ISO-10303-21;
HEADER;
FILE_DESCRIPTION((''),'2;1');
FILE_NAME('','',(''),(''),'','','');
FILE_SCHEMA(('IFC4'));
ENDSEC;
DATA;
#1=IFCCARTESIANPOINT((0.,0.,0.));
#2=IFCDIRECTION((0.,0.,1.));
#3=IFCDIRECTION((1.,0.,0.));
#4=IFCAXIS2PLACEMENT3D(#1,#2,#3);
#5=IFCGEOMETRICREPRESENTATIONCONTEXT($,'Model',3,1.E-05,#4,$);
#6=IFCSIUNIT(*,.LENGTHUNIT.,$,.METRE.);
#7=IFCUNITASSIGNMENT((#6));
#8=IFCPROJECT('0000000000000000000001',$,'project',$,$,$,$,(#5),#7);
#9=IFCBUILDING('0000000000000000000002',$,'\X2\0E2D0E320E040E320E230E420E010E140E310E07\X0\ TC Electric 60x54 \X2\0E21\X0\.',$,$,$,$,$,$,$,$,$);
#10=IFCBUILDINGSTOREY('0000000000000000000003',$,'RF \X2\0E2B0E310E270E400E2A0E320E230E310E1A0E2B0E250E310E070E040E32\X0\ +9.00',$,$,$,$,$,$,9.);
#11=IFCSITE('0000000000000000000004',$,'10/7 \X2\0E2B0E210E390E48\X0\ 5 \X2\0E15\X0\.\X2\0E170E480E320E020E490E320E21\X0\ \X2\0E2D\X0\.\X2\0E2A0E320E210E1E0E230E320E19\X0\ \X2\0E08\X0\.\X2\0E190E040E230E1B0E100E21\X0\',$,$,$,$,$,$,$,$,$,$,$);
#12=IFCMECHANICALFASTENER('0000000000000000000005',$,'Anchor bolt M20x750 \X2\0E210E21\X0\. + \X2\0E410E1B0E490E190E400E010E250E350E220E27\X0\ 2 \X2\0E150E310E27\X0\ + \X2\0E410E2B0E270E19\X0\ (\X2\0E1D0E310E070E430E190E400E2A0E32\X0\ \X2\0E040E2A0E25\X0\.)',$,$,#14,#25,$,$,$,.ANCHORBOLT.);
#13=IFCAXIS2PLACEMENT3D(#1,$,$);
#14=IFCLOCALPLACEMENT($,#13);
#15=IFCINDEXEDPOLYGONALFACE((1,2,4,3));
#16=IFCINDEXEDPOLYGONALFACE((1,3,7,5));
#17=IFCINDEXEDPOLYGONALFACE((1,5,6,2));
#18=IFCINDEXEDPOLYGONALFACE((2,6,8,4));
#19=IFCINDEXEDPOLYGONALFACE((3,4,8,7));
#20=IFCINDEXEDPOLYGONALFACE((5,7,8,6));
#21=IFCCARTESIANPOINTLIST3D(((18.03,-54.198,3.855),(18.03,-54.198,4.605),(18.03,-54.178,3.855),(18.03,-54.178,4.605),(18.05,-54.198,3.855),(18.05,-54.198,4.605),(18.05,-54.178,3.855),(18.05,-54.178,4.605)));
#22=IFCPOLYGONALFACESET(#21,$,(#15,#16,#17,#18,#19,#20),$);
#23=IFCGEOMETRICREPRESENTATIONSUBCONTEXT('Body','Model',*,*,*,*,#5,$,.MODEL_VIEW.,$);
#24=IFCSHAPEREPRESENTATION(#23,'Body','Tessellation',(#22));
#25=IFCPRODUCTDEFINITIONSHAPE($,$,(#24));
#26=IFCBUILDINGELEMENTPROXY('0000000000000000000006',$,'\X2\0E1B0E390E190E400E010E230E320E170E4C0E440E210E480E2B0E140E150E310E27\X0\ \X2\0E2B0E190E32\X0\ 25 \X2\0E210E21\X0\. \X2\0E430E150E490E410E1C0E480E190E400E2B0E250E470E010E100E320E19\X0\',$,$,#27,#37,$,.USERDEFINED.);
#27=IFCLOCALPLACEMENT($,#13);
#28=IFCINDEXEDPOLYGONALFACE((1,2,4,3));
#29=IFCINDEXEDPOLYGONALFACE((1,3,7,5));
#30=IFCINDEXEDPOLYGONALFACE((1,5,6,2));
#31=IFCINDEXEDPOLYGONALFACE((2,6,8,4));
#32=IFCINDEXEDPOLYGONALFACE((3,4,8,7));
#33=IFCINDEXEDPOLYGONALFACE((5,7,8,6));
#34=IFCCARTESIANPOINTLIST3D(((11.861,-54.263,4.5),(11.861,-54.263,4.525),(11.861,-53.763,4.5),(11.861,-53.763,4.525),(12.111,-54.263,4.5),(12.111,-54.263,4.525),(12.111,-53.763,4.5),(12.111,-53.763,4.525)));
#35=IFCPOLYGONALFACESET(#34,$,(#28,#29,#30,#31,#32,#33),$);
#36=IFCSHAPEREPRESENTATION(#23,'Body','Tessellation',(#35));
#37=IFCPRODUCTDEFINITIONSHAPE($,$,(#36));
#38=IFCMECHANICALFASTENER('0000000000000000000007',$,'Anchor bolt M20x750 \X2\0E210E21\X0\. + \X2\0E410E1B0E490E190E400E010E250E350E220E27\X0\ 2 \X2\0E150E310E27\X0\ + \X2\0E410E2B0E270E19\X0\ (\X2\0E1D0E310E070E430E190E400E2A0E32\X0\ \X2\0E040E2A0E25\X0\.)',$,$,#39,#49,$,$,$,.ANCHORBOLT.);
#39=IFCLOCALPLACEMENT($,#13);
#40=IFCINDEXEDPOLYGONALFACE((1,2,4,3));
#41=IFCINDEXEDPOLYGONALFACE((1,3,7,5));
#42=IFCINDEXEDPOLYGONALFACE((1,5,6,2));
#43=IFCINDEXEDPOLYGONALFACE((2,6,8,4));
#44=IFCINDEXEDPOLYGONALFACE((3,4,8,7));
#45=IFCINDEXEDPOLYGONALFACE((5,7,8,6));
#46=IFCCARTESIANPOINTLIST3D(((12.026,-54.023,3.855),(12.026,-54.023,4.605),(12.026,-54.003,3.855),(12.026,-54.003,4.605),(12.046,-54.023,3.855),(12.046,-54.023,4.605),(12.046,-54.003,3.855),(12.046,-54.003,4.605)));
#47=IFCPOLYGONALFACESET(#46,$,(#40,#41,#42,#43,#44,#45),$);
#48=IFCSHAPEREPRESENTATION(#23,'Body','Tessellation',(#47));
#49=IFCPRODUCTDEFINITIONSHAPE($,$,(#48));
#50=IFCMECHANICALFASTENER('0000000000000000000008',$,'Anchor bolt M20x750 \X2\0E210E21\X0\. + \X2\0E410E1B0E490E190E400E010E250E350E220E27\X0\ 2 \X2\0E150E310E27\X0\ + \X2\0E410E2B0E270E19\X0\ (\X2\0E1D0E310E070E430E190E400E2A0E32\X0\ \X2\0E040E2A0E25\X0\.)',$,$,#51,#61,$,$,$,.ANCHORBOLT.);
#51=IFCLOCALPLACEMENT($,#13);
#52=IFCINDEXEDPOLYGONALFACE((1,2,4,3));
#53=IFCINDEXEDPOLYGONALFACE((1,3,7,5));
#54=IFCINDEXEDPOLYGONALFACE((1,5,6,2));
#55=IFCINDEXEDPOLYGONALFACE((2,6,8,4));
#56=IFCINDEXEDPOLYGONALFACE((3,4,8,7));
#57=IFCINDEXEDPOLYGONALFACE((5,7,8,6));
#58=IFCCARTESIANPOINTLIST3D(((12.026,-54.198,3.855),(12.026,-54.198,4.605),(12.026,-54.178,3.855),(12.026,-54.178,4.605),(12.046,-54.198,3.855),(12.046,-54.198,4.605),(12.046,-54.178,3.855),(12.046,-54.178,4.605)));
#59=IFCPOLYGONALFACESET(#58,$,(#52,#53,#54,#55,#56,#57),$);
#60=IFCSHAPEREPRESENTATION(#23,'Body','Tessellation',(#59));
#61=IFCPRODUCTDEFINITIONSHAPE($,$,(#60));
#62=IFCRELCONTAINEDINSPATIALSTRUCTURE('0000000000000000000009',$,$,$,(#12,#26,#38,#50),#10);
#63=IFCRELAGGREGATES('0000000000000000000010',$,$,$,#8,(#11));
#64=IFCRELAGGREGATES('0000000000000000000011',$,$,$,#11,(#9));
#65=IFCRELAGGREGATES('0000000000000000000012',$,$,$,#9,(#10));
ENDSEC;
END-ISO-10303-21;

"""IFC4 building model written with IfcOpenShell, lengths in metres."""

from ifc_helpers import new_model, si_unit, frame, origin, origin_with_axes, origin_2d, place, context, subcontext, project, spatial, rectangle, extrude, element, save


model = new_model("IFC4")

# Units and contexts
model_context = context("Model", 3, precision=1e-05, world=origin_with_axes())
body_context = subcontext(model_context, "Body", "Model", "MODEL_VIEW")
ifc_project = project(units=[si_unit("LENGTHUNIT", "METRE")], contexts=[model_context])

# Site, building, storey
site = spatial("IfcSite", under=ifc_project, Name="10/7 หมู่ 5 ต.ท่าข้าม อ.สามพราน จ.นครปฐม")
building = spatial("IfcBuilding", under=site, Name="อาคารโกดัง TC Electric 60x54 ม.")
storey = spatial("IfcBuildingStorey", under=building, Name="RF หัวเสารับหลังคา +9.00", Elevation=9.0)

# Mechanical fastener
for number, where, z_axis, x_axis, name in (
    (1, (18.04, -54.188, 3.855), (0.0, 0.0, 1.0), (1.0, 0.0, 0.0), "Anchor bolt M20x750 มม. + แป้นเกลียว 2 ตัว + แหวน (ฝังในเสา คสล.)"),
):
    element("IfcMechanicalFastener", number, at=place(None, frame(where, z_axis=z_axis, x_axis=x_axis)), inside=storey, Name=name, PredefinedType="ANCHORBOLT", context=body_context, shape_type="SweptSolid", body=[
        extrude(rectangle(XDim=0.02, YDim=0.02, at=origin_2d()), origin(), (0.0, 0.0, 1.0), 0.75),
    ])

# Building element proxy
proxy_1_placement = place(None, frame((11.986, -54.013, 4.5), z_axis=(0.0, 0.0, 1.0), x_axis=(1.0, 0.0, 0.0)))
element("IfcBuildingElementProxy", 2, at=proxy_1_placement, inside=storey, Name="ปูนเกราท์ไม่หดตัว หนา 25 มม. ใต้แผ่นเหล็กฐาน", PredefinedType="USERDEFINED", context=body_context, shape_type="SweptSolid", body=[
    extrude(rectangle(XDim=0.25, YDim=0.5, at=origin_2d()), origin(), (0.0, 0.0, 1.0), 0.025),
])

# Mechanical fasteners
for number, where, z_axis, x_axis, name in (
    (3, (12.036, -54.013, 3.855), (0.0, 0.0, 1.0), (1.0, 0.0, 0.0), "Anchor bolt M20x750 มม. + แป้นเกลียว 2 ตัว + แหวน (ฝังในเสา คสล.)"),
    (4, (12.036, -54.188, 3.855), (0.0, 0.0, 1.0), (1.0, 0.0, 0.0), "Anchor bolt M20x750 มม. + แป้นเกลียว 2 ตัว + แหวน (ฝังในเสา คสล.)"),
):
    element("IfcMechanicalFastener", number, at=place(None, frame(where, z_axis=z_axis, x_axis=x_axis)), inside=storey, Name=name, PredefinedType="ANCHORBOLT", context=body_context, shape_type="SweptSolid", body=[
        extrude(rectangle(XDim=0.02, YDim=0.02, at=origin_2d()), origin(), (0.0, 0.0, 1.0), 0.75),
    ])

save(model, "model.ifc")
